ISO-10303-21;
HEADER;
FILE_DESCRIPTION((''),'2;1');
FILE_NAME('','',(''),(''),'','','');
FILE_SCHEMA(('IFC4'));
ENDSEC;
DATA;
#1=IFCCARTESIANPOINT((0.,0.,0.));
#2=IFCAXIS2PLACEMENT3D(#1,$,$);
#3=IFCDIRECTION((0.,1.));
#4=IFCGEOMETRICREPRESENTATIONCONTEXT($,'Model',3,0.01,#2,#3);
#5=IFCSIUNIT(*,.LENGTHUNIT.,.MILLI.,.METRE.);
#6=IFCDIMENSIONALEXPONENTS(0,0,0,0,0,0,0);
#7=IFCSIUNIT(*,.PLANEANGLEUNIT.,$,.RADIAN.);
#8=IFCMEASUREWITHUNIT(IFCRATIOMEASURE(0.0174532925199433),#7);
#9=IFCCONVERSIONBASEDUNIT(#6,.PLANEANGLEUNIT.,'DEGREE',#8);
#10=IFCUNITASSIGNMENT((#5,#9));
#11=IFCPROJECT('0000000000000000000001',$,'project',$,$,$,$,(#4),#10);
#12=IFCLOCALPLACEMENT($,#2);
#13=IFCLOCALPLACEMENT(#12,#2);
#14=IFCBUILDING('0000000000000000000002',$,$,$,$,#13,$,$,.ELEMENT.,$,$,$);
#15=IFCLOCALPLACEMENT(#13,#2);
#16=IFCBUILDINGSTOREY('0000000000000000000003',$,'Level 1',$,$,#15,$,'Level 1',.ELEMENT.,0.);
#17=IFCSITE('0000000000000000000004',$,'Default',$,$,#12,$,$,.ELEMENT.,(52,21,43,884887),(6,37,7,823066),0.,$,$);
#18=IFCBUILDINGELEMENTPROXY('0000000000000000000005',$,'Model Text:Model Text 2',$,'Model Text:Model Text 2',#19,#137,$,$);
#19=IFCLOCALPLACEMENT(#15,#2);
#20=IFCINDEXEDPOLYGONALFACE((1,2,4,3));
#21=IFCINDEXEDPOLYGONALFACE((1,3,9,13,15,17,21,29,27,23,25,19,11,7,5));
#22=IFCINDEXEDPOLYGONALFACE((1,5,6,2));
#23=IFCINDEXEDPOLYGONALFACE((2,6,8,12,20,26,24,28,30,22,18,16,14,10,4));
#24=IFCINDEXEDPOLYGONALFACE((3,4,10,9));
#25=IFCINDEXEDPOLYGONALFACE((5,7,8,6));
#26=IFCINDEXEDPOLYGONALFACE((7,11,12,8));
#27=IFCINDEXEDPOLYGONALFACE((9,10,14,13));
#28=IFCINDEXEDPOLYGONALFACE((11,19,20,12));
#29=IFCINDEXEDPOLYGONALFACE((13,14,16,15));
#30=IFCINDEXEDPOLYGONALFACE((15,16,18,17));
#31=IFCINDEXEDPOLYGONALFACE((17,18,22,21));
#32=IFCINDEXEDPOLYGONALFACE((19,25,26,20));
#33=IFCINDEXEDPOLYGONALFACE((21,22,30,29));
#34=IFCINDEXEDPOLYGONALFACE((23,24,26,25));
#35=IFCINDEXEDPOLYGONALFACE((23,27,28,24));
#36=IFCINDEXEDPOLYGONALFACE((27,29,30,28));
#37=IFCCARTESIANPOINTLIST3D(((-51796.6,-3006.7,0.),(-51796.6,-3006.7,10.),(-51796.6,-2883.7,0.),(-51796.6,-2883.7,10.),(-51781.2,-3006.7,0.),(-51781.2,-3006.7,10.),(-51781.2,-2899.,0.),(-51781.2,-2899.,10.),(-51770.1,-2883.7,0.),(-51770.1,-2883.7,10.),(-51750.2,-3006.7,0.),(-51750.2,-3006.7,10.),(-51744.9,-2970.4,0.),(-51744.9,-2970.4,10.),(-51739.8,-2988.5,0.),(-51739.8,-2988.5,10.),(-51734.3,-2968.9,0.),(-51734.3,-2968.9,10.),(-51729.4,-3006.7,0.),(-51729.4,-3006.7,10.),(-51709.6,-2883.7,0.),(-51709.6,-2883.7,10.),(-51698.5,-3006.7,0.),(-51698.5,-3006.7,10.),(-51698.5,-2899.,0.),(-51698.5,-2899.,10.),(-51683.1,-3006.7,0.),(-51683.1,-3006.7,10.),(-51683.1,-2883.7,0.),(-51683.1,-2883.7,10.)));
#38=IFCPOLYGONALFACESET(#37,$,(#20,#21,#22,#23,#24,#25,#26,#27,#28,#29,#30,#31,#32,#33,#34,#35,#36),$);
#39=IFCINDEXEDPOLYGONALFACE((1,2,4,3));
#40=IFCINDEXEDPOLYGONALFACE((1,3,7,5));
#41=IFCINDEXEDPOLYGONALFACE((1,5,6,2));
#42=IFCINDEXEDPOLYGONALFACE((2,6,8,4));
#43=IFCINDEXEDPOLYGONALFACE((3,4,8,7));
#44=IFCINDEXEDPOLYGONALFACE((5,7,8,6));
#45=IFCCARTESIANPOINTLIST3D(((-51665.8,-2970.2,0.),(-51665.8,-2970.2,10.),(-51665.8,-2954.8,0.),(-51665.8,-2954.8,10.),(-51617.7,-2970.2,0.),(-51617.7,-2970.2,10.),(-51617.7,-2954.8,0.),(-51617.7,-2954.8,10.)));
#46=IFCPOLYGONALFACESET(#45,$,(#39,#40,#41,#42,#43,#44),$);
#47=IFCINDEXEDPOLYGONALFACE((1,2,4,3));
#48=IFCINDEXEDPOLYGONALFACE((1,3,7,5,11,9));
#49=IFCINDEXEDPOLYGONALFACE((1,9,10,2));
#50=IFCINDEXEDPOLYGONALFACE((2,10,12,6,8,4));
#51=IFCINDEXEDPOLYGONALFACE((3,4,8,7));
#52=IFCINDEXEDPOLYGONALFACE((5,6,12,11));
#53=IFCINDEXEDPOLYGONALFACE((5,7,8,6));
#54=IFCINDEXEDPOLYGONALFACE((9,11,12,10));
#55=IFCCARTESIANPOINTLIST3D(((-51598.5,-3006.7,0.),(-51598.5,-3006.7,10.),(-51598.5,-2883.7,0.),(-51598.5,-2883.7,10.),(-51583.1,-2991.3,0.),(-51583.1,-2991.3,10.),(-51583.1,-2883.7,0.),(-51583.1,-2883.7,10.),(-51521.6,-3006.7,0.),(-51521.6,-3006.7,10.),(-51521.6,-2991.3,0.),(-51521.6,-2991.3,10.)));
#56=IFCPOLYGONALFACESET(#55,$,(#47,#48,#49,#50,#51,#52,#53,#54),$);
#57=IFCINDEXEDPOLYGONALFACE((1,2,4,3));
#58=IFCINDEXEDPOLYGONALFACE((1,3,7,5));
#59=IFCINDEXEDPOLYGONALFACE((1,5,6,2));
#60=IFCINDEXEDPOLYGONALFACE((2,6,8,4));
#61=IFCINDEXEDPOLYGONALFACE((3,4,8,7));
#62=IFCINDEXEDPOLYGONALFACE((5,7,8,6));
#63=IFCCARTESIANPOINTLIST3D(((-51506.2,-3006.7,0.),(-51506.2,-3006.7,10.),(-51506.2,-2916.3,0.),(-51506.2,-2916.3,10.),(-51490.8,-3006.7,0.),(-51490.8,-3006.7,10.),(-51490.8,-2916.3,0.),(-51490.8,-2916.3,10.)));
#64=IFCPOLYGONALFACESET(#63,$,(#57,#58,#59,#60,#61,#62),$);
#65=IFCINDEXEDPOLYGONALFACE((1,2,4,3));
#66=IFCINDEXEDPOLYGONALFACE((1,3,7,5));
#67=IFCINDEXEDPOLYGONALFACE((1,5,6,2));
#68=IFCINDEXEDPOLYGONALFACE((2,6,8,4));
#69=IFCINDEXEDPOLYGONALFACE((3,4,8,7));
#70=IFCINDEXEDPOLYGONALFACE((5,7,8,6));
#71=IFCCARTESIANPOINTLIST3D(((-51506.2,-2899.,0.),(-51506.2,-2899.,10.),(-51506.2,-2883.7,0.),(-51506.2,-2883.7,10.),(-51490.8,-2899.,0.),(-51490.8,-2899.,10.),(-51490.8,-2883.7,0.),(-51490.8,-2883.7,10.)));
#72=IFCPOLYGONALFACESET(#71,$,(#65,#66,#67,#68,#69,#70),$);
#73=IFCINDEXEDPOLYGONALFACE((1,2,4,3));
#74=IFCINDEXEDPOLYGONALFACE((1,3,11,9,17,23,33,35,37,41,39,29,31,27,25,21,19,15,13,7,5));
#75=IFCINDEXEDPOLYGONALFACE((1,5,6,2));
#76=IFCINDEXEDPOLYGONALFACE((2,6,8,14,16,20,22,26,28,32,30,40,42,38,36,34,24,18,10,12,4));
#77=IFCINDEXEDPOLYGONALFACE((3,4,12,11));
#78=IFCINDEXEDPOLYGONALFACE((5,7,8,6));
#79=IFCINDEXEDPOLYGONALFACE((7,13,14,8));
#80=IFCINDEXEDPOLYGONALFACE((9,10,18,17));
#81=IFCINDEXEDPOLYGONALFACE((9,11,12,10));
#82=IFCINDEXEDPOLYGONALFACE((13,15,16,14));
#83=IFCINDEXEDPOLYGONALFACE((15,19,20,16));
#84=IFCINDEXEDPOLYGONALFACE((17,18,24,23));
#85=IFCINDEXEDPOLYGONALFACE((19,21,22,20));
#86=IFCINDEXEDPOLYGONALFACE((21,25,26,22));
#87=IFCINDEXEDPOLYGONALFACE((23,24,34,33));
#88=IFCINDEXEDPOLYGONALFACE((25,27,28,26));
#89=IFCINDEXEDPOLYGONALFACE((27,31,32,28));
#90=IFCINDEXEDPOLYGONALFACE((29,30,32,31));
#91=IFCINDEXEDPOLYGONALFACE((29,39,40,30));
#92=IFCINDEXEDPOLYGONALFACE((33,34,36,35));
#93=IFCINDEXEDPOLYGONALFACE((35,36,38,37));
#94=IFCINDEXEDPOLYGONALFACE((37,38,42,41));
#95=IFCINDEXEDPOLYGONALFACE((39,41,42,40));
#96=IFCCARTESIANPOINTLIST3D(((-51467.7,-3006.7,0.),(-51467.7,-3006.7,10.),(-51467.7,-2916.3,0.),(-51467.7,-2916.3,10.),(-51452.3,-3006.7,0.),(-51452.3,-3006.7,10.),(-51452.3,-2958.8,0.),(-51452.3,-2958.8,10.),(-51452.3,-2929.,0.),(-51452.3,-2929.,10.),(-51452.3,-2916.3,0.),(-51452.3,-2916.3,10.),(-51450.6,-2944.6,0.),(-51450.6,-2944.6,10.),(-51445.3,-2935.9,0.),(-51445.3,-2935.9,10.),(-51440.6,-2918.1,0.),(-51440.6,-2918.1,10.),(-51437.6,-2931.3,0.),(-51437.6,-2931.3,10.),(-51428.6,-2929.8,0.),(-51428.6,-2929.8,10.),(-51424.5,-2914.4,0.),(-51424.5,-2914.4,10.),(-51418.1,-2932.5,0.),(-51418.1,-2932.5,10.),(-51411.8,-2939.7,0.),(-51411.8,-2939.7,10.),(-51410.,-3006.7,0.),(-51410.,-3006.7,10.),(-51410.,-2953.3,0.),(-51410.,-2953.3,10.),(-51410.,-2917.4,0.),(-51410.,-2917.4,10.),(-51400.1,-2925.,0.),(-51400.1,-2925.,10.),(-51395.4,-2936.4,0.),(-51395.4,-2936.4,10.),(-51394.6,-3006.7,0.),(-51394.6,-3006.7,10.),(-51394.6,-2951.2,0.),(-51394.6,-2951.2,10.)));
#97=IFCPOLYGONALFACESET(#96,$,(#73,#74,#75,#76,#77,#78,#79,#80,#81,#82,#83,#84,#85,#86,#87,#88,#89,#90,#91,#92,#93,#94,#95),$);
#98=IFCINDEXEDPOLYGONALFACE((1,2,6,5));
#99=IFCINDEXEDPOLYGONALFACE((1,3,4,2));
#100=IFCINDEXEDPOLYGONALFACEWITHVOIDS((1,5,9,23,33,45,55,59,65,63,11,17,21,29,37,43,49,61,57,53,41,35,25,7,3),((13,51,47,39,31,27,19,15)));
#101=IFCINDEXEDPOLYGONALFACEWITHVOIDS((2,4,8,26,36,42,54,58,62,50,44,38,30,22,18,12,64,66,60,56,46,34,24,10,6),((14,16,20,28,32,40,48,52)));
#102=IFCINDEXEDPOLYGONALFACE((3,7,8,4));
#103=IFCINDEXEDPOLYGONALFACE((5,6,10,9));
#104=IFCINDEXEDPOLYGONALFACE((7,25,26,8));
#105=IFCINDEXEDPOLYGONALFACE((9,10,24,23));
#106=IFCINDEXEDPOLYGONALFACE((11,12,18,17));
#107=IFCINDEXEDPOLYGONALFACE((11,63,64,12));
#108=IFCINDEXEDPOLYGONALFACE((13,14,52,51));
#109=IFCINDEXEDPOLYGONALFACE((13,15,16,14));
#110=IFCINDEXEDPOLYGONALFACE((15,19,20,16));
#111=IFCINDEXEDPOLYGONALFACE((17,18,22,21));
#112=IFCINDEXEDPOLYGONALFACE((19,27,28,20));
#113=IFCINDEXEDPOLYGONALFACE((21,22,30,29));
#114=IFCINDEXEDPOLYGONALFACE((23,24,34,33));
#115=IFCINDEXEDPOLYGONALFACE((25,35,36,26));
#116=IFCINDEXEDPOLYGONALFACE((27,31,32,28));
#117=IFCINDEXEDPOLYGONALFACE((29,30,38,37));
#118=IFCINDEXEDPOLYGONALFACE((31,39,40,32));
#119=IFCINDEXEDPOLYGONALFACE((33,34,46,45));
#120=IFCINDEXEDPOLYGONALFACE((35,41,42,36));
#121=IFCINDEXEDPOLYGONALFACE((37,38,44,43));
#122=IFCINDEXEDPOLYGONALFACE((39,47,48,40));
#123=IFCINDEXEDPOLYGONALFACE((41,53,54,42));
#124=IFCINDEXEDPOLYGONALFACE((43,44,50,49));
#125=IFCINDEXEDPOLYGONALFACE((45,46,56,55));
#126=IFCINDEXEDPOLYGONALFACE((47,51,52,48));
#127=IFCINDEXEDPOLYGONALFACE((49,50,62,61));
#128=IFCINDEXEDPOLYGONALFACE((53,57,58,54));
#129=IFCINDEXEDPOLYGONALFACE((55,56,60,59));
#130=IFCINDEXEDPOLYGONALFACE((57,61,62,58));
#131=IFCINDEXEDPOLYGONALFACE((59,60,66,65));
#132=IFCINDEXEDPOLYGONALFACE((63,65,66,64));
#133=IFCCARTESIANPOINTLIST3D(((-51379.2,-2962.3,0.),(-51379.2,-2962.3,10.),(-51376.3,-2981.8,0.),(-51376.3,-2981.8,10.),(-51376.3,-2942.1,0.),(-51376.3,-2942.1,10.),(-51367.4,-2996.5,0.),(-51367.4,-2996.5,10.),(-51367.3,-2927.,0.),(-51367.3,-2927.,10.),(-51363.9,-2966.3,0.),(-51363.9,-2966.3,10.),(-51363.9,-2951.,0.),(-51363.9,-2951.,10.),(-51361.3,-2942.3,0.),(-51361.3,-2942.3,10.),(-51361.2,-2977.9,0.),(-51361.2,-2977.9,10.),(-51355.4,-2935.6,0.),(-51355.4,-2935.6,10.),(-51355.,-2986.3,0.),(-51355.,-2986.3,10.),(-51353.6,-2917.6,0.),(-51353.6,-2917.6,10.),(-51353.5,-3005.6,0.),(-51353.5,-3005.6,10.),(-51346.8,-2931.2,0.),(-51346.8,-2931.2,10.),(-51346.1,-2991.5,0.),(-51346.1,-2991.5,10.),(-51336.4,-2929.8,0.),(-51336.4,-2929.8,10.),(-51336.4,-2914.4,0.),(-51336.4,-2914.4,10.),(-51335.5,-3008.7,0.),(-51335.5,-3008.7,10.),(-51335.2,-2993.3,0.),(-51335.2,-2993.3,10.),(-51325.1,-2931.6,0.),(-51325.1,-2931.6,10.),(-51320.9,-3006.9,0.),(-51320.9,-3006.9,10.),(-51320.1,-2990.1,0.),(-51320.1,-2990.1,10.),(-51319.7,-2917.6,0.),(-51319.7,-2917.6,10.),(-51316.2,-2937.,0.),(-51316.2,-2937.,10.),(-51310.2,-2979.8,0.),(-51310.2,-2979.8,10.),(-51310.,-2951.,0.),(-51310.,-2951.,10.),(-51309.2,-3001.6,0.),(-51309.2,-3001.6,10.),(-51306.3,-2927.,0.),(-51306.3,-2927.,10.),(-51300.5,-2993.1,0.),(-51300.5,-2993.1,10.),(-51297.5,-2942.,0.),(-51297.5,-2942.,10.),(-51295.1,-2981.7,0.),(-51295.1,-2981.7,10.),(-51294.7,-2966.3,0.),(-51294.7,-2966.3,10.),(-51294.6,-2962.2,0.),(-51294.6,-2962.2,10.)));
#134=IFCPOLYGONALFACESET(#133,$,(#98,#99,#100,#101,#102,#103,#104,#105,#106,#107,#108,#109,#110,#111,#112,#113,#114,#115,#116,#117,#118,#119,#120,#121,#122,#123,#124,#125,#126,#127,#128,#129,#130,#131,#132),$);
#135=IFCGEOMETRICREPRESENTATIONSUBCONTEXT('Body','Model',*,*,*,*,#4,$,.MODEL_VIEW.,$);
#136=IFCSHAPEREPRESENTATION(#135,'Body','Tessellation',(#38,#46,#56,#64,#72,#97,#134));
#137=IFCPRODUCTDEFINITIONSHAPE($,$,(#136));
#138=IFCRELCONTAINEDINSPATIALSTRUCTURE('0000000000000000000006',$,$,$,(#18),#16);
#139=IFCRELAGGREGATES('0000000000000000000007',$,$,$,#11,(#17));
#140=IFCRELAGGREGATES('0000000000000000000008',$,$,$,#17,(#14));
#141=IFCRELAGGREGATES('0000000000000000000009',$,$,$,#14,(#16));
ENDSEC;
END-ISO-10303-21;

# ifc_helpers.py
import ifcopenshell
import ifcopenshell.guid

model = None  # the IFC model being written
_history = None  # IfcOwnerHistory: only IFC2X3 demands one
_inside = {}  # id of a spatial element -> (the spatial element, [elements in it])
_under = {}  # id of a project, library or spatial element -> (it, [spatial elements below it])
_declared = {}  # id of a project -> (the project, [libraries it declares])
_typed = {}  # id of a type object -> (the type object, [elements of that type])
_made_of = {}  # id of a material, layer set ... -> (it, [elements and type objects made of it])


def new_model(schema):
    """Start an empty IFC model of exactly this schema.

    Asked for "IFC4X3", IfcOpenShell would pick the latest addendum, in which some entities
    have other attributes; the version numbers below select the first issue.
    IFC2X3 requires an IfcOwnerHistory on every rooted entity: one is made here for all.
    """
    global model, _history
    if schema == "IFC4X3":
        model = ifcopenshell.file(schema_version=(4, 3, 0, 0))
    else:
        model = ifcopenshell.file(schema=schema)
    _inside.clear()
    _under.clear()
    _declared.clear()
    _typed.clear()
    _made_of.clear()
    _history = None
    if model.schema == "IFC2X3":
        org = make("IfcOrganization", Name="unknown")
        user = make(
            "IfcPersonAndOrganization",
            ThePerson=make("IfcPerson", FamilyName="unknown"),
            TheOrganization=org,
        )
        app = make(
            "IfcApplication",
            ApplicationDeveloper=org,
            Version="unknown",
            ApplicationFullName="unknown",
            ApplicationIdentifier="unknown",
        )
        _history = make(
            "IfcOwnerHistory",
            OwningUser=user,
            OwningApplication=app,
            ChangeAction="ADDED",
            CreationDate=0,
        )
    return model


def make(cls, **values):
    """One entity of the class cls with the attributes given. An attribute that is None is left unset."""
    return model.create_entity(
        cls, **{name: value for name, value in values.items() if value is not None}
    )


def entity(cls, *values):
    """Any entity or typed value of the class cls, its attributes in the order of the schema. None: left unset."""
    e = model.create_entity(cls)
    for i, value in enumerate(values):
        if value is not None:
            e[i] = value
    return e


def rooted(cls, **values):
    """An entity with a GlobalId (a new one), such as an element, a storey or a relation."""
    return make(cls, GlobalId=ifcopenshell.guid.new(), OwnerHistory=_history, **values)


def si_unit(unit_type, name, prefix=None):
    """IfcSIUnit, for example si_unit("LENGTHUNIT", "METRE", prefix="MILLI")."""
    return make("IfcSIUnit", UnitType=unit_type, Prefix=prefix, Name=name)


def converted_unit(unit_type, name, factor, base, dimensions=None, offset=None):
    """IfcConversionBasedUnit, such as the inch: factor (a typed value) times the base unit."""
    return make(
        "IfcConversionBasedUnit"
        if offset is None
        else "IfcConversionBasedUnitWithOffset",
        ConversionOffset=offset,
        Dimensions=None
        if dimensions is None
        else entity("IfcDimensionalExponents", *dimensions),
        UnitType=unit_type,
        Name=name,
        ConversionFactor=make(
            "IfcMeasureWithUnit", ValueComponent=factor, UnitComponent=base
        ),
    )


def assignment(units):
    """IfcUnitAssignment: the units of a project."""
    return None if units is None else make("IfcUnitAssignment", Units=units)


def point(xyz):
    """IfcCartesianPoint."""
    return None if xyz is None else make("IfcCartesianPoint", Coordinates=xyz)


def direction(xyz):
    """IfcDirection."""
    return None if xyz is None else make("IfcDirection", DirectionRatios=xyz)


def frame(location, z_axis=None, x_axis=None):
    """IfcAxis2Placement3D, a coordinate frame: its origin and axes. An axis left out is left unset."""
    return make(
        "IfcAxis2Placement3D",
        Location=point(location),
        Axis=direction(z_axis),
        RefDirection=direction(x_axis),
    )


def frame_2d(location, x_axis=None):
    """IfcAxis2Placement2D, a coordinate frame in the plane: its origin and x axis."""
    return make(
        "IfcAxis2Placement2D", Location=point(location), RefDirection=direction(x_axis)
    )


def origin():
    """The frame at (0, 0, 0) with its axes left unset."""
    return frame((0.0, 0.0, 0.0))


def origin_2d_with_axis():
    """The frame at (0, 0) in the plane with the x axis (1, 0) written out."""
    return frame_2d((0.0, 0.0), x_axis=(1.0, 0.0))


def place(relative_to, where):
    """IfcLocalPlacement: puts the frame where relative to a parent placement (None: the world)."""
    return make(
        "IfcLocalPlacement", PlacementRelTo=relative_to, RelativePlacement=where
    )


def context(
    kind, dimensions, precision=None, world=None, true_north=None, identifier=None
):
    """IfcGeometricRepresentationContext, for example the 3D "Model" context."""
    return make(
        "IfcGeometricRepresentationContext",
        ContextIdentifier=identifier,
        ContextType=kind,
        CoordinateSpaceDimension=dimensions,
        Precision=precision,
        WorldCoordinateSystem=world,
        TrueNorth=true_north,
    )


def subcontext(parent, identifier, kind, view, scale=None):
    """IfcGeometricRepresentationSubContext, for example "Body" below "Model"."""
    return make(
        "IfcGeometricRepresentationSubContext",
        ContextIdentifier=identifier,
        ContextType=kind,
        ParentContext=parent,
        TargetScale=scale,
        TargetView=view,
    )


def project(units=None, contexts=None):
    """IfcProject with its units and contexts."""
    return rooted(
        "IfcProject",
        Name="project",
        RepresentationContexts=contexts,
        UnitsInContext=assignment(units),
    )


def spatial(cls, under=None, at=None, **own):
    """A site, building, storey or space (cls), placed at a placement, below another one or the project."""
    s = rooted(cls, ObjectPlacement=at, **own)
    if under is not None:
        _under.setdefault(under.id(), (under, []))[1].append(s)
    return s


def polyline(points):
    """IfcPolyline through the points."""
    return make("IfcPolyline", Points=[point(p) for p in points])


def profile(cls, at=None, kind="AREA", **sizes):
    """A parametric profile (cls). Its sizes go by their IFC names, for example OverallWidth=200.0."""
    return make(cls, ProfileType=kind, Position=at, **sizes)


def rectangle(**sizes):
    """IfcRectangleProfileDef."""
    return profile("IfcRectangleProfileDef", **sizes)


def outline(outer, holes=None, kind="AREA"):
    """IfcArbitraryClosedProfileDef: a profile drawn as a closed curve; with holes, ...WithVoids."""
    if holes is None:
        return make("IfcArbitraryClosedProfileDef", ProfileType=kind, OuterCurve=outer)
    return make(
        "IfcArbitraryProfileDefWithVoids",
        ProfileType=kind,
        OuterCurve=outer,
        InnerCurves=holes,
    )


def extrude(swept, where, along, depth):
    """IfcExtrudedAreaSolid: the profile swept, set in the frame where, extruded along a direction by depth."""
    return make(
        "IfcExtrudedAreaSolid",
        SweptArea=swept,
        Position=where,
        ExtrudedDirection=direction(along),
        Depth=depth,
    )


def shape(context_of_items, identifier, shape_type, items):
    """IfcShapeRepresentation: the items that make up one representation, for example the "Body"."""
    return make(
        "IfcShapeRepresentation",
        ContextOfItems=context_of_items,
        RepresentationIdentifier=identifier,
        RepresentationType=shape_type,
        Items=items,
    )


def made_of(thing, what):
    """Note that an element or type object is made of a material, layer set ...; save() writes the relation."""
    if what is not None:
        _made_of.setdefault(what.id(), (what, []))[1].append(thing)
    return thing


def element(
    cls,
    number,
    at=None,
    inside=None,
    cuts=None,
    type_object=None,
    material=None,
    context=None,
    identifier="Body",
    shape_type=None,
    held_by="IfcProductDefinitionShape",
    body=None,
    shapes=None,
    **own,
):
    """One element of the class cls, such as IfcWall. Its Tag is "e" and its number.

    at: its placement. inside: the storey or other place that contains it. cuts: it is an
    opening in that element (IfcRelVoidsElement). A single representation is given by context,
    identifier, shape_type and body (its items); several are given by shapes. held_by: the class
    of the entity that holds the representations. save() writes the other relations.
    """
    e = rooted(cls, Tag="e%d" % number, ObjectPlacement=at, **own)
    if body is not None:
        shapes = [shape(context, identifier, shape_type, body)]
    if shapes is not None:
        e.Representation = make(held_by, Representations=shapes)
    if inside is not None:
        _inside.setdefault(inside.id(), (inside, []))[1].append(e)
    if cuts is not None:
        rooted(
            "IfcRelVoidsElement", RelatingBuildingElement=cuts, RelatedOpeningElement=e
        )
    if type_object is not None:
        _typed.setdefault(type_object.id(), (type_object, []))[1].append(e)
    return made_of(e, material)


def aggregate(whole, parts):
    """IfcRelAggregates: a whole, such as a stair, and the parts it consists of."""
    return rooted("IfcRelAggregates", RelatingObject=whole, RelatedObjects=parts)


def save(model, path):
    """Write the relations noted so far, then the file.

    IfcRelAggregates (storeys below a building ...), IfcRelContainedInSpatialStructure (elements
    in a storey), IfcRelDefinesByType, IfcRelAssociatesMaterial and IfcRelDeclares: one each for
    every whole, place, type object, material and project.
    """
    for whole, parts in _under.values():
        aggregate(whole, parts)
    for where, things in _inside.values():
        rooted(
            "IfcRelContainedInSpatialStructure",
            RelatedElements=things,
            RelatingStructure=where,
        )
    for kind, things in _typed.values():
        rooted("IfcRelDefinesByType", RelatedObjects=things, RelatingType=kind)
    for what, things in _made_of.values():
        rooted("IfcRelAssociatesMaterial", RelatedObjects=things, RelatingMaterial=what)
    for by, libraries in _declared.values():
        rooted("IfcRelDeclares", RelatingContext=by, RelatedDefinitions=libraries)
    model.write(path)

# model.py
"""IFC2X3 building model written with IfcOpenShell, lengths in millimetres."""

from ifc_helpers import new_model, entity, si_unit, converted_unit, direction, frame, frame_2d, origin, origin_2d_with_axis, place, context, subcontext, project, spatial, polyline, rectangle, outline, extrude, element, save


model = new_model("IFC2X3")

# Units and contexts
model_context = context("Model", 3, precision=0.01, world=origin(), true_north=direction((0.0, 1.0)))
body_context = subcontext(model_context, "Body", "Model", "MODEL_VIEW")
ifc_project = project(units=[si_unit("LENGTHUNIT", "METRE", prefix="MILLI"), converted_unit("PLANEANGLEUNIT", "DEGREE", entity("IfcRatioMeasure", 0.0174532925199433), si_unit("PLANEANGLEUNIT", "RADIAN"), dimensions=[0, 0, 0, 0, 0, 0, 0])], contexts=[model_context])

# Site, building, storey
site_placement = place(None, origin())
site = spatial("IfcSite", under=ifc_project, at=site_placement, Name="Default", CompositionType="ELEMENT", RefLatitude=(52, 21, 43, 884887), RefLongitude=(6, 37, 7, 823066), RefElevation=0.0)
building_placement = place(site_placement, origin())
building = spatial("IfcBuilding", under=site, at=building_placement, CompositionType="ELEMENT")
storey_placement = place(building_placement, origin())
storey = spatial("IfcBuildingStorey", under=building, at=storey_placement, Name="Level 1", LongName="Level 1", CompositionType="ELEMENT", Elevation=0.0)

# Building element proxy
proxy_1_placement = place(storey_placement, origin())
element("IfcBuildingElementProxy", 1, at=proxy_1_placement, inside=storey, Name="Model Text:Model Text 2", ObjectType="Model Text:Model Text 2", context=body_context, shape_type="SweptSolid", body=[
    extrude(outline(polyline([(-56.8, -53.3), (-41.4, -53.3), (-41.4, 54.4), (-10.5, -53.3), (10.4, -53.3), (41.3, 54.4), (41.3, -53.3), (56.7, -53.3), (56.7, 69.7), (30.2, 69.7), (5.5, -15.5), (0.0, -35.1), (-5.1, -17.0), (-30.3, 69.7), (-56.8, 69.7), (-56.8, -53.3)])), frame((-51739.8, -2953.4, 0.0)), (0.0, 0.0, 1.0), 10.0),
    extrude(rectangle(XDim=48.1, YDim=15.4, at=origin_2d_with_axis()), frame((-51641.7, -2962.5, 0.0)), (0.0, 0.0, 1.0), 10.0),
    extrude(outline(polyline([(-30.8, -46.2), (46.2, -46.2), (46.2, -30.8), (-15.4, -30.8), (-15.4, 76.9), (-30.8, 76.9), (-30.8, -46.2)])), frame((-51567.7, -2960.6, 0.0)), (0.0, 0.0, 1.0), 10.0),
    extrude(rectangle(XDim=15.4, YDim=90.4, at=frame_2d((0.0, 0.0), x_axis=(1.0, 0.0))), frame((-51498.5, -2961.5, 0.0)), (0.0, 0.0, 1.0), 10.0),
    extrude(rectangle(XDim=15.4, YDim=15.4, at=frame_2d((0.0, 0.0), x_axis=(1.0, 0.0))), frame((-51498.5, -2891.3, 0.0)), (0.0, 0.0, 1.0), 10.0),
    extrude(outline(polyline([(-38.4, -60.2), (-23.0, -60.2), (-23.0, -12.3), (-21.2, 1.9), (-16.0, 10.7), (-8.3, 15.2), (0.7, 16.7), (11.3, 14.0), (17.6, 6.8), (19.3, -6.8), (19.3, -60.2), (34.7, -60.2), (34.7, -4.7), (33.9, 10.2), (29.3, 21.5), (19.4, 29.2), (4.9, 32.1), (-11.2, 28.5), (-23.0, 17.6), (-23.0, 30.2), (-38.4, 30.2), (-38.4, -60.2)])), frame((-51429.4, -2946.5, 0.0)), (0.0, 0.0, 1.0), 10.0),
    extrude(outline(polyline([(-9.9, -25.0), (-19.0, -37.1), (-7.1, -41.1), (5.1, -40.8), (17.0, -36.1), (28.4, -26.8), (38.8, -11.8), (41.9, 4.6), (37.5, 21.1), (25.5, 36.8), (8.9, 48.7), (-8.2, 52.8), (-24.5, 49.5), (-38.7, 39.3), (-48.1, 25.1), (-50.6, 9.0), (-45.9, -7.8), (-33.4, -23.9), (-30.4, -26.7), (17.7, 23.0), (24.1, 13.0), (25.9, 2.7), (23.5, -7.3), (17.1, -16.4), (4.3, -25.0), (-9.9, -25.0)]), holes=[polyline([(6.7, 33.7), (-30.8, -5.0), (-36.5, 9.1), (-34.2, 19.3), (-27.6, 28.7), (-19.4, 35.1), (-10.3, 38.3), (-1.3, 37.9), (6.7, 33.7)])]), frame((-51335.0, -2969.6, 0.0), z_axis=(0.0, 0.0, -1.0), x_axis=(-0.695421, -0.718602, 0.0)), (0.0, 0.0, -1.0), 10.0),
])

save(model, "model.ifc")
